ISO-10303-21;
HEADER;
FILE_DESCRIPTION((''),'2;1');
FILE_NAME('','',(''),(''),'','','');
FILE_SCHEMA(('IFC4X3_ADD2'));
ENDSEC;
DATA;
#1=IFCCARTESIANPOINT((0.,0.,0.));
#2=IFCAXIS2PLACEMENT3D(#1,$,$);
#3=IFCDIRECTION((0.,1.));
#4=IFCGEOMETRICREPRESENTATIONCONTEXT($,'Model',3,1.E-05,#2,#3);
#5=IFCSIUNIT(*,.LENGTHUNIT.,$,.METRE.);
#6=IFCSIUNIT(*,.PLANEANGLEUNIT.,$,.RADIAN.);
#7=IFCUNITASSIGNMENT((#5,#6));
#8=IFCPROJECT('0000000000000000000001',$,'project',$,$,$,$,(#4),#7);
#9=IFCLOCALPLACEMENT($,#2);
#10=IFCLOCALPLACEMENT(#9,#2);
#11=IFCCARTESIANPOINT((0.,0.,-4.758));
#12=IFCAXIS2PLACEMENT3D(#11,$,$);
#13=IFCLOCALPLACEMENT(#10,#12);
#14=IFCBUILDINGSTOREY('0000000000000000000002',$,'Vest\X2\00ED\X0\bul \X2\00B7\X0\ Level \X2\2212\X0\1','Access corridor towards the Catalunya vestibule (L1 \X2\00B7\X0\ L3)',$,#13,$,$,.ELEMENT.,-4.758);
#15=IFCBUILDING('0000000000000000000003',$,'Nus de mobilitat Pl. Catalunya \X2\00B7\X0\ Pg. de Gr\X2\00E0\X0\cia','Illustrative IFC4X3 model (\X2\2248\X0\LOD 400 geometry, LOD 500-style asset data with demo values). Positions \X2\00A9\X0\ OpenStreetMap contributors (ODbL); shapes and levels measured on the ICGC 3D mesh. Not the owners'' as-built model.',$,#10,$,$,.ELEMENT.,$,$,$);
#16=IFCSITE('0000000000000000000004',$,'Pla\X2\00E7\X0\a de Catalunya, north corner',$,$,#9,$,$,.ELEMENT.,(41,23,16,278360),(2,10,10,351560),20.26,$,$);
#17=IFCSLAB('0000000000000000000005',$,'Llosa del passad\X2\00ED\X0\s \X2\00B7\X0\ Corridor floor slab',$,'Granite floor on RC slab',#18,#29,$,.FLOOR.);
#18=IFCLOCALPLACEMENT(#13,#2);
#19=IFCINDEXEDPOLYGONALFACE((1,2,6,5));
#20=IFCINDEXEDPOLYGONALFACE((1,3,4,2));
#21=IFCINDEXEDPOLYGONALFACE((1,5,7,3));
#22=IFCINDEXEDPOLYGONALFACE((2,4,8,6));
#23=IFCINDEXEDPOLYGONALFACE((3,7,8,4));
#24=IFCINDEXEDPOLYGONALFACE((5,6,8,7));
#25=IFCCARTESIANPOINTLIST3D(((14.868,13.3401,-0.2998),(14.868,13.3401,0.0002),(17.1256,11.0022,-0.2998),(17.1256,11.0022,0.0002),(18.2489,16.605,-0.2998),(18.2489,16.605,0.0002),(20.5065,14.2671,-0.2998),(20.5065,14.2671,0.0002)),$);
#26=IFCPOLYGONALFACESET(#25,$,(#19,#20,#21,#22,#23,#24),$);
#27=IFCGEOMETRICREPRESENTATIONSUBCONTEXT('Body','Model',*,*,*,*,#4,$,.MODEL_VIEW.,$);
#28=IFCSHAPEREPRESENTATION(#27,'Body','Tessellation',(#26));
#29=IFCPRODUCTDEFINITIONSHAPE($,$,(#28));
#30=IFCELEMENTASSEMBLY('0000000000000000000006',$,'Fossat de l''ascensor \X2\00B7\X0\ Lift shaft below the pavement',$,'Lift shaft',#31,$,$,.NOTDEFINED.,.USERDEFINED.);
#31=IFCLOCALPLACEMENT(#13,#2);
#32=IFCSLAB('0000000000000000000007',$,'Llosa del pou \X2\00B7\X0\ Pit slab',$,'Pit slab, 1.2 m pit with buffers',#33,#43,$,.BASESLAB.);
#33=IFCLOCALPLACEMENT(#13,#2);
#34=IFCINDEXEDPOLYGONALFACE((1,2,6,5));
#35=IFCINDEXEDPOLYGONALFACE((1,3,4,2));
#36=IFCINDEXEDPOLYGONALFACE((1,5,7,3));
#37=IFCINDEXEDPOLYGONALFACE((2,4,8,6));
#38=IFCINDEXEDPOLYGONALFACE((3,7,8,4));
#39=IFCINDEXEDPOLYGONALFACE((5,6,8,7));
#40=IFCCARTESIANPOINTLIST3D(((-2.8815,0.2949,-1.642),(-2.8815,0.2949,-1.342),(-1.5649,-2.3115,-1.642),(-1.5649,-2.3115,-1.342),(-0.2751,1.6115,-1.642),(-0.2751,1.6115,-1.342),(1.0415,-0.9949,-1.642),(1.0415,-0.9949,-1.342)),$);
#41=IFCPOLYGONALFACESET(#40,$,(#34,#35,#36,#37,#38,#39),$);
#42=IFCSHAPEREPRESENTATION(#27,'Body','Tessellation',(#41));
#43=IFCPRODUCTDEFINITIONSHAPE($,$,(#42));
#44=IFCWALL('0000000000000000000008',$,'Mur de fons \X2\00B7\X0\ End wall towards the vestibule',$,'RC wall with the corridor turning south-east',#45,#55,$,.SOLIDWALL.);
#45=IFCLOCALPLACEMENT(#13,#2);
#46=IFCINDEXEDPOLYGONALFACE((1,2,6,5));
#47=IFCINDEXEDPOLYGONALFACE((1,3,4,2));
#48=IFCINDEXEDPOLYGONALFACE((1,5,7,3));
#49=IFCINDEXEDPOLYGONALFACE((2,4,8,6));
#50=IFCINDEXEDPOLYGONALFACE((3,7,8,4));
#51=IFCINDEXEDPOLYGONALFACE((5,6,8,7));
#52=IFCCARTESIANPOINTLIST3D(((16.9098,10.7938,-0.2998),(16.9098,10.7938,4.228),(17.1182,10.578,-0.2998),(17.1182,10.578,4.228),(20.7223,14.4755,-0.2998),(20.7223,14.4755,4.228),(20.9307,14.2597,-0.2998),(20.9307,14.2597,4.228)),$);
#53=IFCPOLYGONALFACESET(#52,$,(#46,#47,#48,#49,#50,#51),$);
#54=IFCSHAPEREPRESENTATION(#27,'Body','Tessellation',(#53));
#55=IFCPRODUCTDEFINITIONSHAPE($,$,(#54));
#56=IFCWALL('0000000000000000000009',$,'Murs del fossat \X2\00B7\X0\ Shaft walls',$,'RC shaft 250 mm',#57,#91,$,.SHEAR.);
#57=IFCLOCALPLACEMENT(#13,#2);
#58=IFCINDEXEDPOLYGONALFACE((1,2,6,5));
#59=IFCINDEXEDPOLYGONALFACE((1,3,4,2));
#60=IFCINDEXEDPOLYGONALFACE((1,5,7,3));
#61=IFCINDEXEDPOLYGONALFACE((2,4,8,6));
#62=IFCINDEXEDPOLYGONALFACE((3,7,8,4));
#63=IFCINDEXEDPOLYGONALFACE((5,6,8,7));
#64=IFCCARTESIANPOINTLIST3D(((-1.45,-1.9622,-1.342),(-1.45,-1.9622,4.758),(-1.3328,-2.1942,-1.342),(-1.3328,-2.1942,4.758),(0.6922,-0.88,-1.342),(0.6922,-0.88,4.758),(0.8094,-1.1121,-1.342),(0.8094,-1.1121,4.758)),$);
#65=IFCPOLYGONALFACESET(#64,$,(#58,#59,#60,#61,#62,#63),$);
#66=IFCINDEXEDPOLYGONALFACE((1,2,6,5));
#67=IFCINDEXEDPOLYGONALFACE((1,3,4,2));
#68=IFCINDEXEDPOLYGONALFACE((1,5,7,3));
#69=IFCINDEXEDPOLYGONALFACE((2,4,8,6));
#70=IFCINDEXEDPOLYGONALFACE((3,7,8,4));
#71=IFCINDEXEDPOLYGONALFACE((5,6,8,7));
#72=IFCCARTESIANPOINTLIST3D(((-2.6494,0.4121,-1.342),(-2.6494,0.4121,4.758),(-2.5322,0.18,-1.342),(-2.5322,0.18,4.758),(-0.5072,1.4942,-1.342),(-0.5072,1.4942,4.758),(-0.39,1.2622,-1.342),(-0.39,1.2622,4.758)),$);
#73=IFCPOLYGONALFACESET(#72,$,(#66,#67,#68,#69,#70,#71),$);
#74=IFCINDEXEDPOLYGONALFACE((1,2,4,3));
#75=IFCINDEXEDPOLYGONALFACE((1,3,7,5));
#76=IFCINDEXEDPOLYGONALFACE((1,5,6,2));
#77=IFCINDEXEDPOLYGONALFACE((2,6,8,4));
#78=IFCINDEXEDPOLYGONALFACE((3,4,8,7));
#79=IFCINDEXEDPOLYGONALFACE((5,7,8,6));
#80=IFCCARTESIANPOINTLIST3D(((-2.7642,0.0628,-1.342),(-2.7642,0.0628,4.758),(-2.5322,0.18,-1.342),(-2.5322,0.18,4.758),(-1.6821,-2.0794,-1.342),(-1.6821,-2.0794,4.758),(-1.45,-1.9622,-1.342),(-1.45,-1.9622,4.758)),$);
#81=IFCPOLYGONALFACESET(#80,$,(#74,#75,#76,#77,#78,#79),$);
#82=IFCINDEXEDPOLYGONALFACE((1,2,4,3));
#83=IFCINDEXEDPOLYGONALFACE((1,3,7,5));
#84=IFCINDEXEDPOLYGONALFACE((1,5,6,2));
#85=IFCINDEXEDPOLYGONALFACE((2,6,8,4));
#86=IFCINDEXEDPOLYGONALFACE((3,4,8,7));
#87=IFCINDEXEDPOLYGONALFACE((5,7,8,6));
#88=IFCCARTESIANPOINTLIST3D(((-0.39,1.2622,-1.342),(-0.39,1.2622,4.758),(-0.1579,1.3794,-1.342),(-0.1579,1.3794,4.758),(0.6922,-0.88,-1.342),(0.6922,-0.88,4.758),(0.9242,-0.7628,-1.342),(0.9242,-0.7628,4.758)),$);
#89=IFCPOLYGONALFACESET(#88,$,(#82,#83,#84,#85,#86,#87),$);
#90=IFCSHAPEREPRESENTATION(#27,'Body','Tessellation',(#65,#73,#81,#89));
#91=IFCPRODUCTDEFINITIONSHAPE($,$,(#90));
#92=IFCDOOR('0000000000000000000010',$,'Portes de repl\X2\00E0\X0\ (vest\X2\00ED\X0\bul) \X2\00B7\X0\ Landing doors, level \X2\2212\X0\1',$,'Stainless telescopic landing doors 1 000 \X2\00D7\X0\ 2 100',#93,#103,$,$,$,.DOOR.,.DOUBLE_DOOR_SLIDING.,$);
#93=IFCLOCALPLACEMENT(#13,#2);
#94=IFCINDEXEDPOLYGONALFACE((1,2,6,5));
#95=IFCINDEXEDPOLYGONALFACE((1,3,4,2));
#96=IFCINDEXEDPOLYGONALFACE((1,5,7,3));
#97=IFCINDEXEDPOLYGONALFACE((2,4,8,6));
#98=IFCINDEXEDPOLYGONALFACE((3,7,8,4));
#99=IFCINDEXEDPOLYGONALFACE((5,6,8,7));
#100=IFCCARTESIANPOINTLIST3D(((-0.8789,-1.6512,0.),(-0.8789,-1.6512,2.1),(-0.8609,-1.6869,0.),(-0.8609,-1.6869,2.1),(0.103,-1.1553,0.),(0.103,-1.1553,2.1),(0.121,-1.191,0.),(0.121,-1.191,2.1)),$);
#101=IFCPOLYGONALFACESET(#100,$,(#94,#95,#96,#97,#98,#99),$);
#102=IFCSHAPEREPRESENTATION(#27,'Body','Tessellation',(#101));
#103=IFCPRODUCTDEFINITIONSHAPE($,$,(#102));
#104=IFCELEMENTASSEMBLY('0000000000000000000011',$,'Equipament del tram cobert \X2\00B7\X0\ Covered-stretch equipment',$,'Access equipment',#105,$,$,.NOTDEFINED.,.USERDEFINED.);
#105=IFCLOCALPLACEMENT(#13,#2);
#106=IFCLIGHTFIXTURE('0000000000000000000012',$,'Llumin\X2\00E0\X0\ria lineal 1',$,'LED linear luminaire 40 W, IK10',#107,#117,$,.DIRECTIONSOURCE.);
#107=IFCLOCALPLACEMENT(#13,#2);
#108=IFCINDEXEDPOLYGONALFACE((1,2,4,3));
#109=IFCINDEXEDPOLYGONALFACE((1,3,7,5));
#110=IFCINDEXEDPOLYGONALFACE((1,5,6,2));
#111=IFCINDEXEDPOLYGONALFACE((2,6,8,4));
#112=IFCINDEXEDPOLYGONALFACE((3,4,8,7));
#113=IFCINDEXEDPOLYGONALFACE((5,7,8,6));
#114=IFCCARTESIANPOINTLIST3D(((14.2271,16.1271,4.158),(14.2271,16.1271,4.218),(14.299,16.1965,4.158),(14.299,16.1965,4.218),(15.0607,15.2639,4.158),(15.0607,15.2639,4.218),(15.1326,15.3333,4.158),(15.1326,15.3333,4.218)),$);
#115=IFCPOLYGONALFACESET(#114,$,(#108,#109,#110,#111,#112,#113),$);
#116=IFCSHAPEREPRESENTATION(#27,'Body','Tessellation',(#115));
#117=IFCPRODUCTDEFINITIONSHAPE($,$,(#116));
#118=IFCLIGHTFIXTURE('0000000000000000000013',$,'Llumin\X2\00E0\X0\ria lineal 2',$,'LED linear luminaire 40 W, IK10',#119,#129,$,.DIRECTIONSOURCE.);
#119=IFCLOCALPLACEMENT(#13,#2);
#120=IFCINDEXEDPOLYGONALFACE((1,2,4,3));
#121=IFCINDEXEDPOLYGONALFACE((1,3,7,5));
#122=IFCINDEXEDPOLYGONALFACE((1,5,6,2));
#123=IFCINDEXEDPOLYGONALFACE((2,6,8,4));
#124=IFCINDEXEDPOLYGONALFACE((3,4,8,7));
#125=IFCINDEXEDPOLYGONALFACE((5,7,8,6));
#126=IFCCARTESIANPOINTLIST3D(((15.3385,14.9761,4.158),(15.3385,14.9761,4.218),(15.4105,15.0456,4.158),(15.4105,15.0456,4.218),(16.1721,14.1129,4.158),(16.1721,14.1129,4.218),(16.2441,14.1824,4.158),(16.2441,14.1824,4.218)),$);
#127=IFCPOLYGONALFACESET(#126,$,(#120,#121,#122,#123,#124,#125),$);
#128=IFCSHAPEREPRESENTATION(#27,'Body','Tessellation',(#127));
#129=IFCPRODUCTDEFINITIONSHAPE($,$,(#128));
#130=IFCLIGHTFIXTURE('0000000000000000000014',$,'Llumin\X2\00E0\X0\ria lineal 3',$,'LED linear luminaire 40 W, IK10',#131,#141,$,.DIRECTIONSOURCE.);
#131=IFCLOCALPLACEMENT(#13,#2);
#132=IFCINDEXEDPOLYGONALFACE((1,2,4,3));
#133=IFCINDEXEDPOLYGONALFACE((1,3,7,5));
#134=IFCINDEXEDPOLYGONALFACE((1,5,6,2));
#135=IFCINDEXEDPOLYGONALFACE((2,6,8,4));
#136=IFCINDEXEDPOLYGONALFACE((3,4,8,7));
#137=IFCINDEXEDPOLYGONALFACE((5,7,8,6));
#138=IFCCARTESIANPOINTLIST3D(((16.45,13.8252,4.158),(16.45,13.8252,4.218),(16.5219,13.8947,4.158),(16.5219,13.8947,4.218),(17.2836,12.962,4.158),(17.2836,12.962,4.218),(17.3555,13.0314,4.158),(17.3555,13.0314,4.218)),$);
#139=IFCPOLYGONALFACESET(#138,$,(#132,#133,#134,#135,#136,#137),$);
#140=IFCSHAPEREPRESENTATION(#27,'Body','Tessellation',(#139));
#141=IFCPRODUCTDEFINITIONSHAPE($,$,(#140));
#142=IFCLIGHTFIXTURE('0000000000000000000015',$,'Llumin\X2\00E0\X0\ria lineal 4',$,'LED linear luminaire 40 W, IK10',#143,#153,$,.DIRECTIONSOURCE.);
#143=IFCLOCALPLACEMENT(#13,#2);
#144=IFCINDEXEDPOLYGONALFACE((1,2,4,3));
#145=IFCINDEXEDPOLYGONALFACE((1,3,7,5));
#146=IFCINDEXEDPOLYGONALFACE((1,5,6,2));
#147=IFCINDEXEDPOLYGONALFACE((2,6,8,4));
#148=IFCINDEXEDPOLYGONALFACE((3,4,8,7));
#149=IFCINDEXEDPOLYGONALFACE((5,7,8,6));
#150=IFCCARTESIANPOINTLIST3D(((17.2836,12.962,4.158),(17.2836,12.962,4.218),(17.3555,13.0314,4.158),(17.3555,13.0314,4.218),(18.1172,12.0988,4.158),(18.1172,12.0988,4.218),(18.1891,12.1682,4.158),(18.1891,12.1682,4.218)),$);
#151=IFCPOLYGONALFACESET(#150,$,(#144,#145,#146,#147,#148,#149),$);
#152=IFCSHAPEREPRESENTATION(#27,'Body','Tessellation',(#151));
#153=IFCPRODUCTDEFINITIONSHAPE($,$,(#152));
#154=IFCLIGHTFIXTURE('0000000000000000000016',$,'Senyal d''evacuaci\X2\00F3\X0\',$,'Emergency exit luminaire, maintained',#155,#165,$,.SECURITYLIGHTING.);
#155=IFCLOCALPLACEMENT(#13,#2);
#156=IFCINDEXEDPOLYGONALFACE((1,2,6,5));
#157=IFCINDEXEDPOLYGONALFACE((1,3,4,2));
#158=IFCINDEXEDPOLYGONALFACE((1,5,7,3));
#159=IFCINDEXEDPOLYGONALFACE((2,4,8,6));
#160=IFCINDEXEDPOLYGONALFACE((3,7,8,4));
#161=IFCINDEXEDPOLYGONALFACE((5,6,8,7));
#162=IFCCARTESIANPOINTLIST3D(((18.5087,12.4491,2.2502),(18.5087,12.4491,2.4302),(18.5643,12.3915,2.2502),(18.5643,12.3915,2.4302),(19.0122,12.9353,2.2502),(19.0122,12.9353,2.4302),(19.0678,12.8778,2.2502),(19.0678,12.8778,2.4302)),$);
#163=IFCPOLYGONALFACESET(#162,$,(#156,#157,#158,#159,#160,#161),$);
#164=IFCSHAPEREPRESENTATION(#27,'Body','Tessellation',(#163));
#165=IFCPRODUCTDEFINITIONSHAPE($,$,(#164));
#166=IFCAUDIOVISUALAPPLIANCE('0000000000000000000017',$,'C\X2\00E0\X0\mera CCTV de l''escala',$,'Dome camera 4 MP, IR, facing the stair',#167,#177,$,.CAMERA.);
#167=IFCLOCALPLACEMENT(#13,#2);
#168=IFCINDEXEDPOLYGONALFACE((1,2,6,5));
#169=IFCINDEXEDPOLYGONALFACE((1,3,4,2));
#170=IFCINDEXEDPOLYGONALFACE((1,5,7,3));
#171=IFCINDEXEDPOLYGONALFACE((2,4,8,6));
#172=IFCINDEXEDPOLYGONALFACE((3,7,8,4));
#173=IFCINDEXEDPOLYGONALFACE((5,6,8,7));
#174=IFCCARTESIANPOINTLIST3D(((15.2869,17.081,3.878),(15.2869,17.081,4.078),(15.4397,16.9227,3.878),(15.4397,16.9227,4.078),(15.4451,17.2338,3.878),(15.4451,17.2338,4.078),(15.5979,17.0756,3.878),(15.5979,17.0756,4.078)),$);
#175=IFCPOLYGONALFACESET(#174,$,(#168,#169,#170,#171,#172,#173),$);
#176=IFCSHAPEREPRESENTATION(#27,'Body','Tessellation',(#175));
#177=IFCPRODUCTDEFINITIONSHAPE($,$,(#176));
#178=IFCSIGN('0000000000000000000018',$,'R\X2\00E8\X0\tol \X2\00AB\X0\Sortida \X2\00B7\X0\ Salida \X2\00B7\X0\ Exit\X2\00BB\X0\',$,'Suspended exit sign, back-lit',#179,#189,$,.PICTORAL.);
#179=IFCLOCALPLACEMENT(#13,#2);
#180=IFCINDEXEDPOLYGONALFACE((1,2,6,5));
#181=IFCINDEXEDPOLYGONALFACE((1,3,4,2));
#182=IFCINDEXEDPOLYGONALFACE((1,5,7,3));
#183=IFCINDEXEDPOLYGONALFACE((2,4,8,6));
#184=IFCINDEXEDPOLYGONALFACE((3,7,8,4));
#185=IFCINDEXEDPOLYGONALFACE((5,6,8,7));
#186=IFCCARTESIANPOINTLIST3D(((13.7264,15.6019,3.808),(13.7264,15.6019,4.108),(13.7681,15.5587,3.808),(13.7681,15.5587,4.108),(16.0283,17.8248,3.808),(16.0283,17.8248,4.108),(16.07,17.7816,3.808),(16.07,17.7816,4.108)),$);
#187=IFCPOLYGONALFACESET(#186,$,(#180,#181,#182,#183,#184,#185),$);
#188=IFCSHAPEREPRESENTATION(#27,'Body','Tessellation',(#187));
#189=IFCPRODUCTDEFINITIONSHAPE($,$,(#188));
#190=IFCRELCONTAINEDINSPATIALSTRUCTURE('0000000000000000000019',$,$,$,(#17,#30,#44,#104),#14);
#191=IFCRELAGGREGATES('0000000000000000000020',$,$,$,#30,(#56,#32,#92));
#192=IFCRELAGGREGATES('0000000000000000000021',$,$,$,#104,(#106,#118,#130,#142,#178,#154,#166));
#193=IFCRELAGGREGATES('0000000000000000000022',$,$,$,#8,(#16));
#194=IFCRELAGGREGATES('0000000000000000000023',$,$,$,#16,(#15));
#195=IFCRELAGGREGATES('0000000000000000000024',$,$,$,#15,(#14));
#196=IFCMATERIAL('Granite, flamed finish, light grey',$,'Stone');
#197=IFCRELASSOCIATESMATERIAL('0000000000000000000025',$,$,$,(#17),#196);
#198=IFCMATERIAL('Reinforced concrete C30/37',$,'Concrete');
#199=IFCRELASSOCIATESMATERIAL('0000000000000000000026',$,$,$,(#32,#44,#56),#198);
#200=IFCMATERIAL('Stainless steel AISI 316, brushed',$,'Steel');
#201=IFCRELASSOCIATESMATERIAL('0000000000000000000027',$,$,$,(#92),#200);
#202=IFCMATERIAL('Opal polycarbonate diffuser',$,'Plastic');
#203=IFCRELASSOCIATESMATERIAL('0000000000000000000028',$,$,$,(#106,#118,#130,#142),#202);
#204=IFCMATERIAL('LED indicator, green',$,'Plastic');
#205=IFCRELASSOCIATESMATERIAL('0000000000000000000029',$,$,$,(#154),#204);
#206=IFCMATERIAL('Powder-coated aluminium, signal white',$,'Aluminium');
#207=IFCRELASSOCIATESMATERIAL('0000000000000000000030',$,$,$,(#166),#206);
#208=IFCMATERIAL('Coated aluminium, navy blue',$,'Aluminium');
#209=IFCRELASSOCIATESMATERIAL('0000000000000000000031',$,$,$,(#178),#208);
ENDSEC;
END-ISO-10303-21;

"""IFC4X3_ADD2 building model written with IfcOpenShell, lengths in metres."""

from ifc_helpers import new_model, si_unit, direction, frame, frame_2d, origin, place, context, subcontext, project, spatial, rectangle, extrude, material, element, aggregate, save


model = new_model("IFC4X3_ADD2")

# Units and contexts
model_context = context("Model", 3, precision=1e-05, world=origin(), true_north=direction((0.0, 1.0)))
body_context = subcontext(model_context, "Body", "Model", "MODEL_VIEW")
ifc_project = project(units=[si_unit("LENGTHUNIT", "METRE"), si_unit("PLANEANGLEUNIT", "RADIAN")], contexts=[model_context])

# Site, building, storey
site_placement = place(None, origin())
site = spatial("IfcSite", under=ifc_project, at=site_placement, Name="Plaça de Catalunya, north corner", CompositionType="ELEMENT", RefLatitude=(41, 23, 16, 278360), RefLongitude=(2, 10, 10, 351560), RefElevation=20.26)
building_placement = place(site_placement, origin())
building = spatial("IfcBuilding", under=site, at=building_placement, Name="Nus de mobilitat Pl. Catalunya · Pg. de Gràcia", Description="Illustrative IFC4X3 model (≈LOD 400 geometry, LOD 500-style asset data with demo values). Positions © OpenStreetMap contributors (ODbL); shapes and levels measured on the ICGC 3D mesh. Not the owners' as-built model.", CompositionType="ELEMENT")
storey_placement = place(building_placement, frame((0.0, 0.0, -4.758)))
storey = spatial("IfcBuildingStorey", under=building, at=storey_placement, Name="Vestíbul · Level −1", Description="Access corridor towards the Catalunya vestibule (L1 · L3)", CompositionType="ELEMENT", Elevation=-4.758)

# Slab
ifc_material_1 = material(Name="Granite, flamed finish, light grey", Category="Stone")
slab_1_placement = place(building_placement, origin())
element("IfcSlab", 1, at=slab_1_placement, inside=storey, material=ifc_material_1, Name="Llosa del passadís · Corridor floor slab", ObjectType="Granite floor on RC slab", PredefinedType="FLOOR", context=body_context, shape_type="SweptSolid", body=[
    extrude(rectangle(XDim=3.25, YDim=4.7, at=frame_2d((0.0, 0.0), x_axis=(0.694658, -0.71934))), frame((17.6872, 13.8036, -5.0578)), (0.0, 0.0, 1.0), 0.3),
])

# Element assembly, slab
assembly_1_placement = place(building_placement, origin())
assembly_1 = element("IfcElementAssembly", 2, at=assembly_1_placement, inside=storey, Name="Fossat de l'ascensor · Lift shaft below the pavement", ObjectType="Lift shaft", AssemblyPlace="NOTDEFINED", PredefinedType="USERDEFINED")
ifc_material_2 = material(Name="Reinforced concrete C30/37", Category="Concrete")
slab_2_placement = place(building_placement, origin())
slab_2 = element("IfcSlab", 3, at=slab_2_placement, material=ifc_material_2, Name="Llosa del pou · Pit slab", ObjectType="Pit slab, 1.2 m pit with buffers", PredefinedType="BASESLAB", context=body_context, shape_type="SweptSolid", body=[
    extrude(rectangle(XDim=2.92, YDim=2.92, at=frame_2d((0.0, 0.0), x_axis=(0.892586, 0.450878))), frame((-0.92, -0.35, -6.4)), (0.0, 0.0, 1.0), 0.3),
])

# Walls
wall_1_placement = place(building_placement, origin())
element("IfcWall", 4, at=wall_1_placement, inside=storey, material=ifc_material_2, Name="Mur de fons · End wall towards the vestibule", ObjectType="RC wall with the corridor turning south-east", PredefinedType="SOLIDWALL", context=body_context, shape_type="SweptSolid", body=[
    extrude(rectangle(XDim=0.3, YDim=5.3, at=frame_2d((0.0, 0.0), x_axis=(0.694658, -0.71934))), frame((18.9202, 12.5268, -5.0578)), (0.0, 0.0, 1.0), 4.5278),
])
wall_2_placement = place(building_placement, origin())
wall_2 = element("IfcWall", 5, at=wall_2_placement, material=ifc_material_2, Name="Murs del fossat · Shaft walls", ObjectType="RC shaft 250 mm", PredefinedType="SHEAR", context=body_context, shape_type="SweptSolid", body=[
    extrude(rectangle(XDim=2.4, YDim=0.26, at=frame_2d((0.0, 0.0), x_axis=(0.892586, 0.450878))), frame((-0.3203, -1.5371, -6.1)), (0.0, 0.0, 1.0), 6.1),
    extrude(rectangle(XDim=2.4, YDim=0.26, at=frame_2d((0.0, 0.0), x_axis=(0.892586, 0.450878))), frame((-1.5197, 0.8371, -6.1)), (0.0, 0.0, 1.0), 6.1),
    extrude(rectangle(XDim=0.26, YDim=2.4, at=frame_2d((0.0, 0.0), x_axis=(0.892586, 0.450878))), frame((-2.1071, -0.9497, -6.1)), (0.0, 0.0, 1.0), 6.1),
    extrude(rectangle(XDim=0.26, YDim=2.4, at=frame_2d((0.0, 0.0), x_axis=(0.892586, 0.450878))), frame((0.2671, 0.2497, -6.1)), (0.0, 0.0, 1.0), 6.1),
])

# Door
ifc_material_3 = material(Name="Stainless steel AISI 316, brushed", Category="Steel")
door_placement = place(building_placement, origin())
door = element("IfcDoor", 6, at=door_placement, material=ifc_material_3, Name="Portes de replà (vestíbul) · Landing doors, level −1", ObjectType="Stainless telescopic landing doors 1 000 × 2 100", OperationType="DOUBLE_DOOR_SLIDING", PredefinedType="DOOR", context=body_context, shape_type="SweptSolid", body=[
    extrude(rectangle(XDim=1.1, YDim=0.04, at=frame_2d((0.0, 0.0), x_axis=(0.892586, 0.450878))), frame((-0.3789, -1.4211, -4.758)), (0.0, 0.0, 1.0), 2.1),
])
aggregate(assembly_1, [wall_2, slab_2, door])

# Element assembly, light fixtures, audio visual appliance, sign
assembly_2_placement = place(building_placement, origin())
assembly_2 = element("IfcElementAssembly", 7, at=assembly_2_placement, inside=storey, Name="Equipament del tram cobert · Covered-stretch equipment", ObjectType="Access equipment", AssemblyPlace="NOTDEFINED", PredefinedType="USERDEFINED")
ifc_material_4 = material(Name="Opal polycarbonate diffuser", Category="Plastic")
light_fixture_1_placement = place(building_placement, origin())
light_fixture_1 = element("IfcLightFixture", 8, at=light_fixture_1_placement, material=ifc_material_4, Name="Lluminària lineal 1", ObjectType="LED linear luminaire 40 W, IK10", PredefinedType="DIRECTIONSOURCE", context=body_context, shape_type="SweptSolid", body=[
    extrude(rectangle(XDim=1.2, YDim=0.1, at=frame_2d((0.0, 0.0), x_axis=(0.694658, -0.71934))), frame((14.6798, 15.7302, -0.6)), (0.0, 0.0, 1.0), 0.06),
])
light_fixture_2_placement = place(building_placement, origin())
light_fixture_2 = element("IfcLightFixture", 9, at=light_fixture_2_placement, material=ifc_material_4, Name="Lluminària lineal 2", ObjectType="LED linear luminaire 40 W, IK10", PredefinedType="DIRECTIONSOURCE", context=body_context, shape_type="SweptSolid", body=[
    extrude(rectangle(XDim=1.2, YDim=0.1, at=frame_2d((0.0, 0.0), x_axis=(0.694658, -0.71934))), frame((15.7913, 14.5793, -0.6)), (0.0, 0.0, 1.0), 0.06),
])
light_fixture_3_placement = place(building_placement, origin())
light_fixture_3 = element("IfcLightFixture", 10, at=light_fixture_3_placement, material=ifc_material_4, Name="Lluminària lineal 3", ObjectType="LED linear luminaire 40 W, IK10", PredefinedType="DIRECTIONSOURCE", context=body_context, shape_type="SweptSolid", body=[
    extrude(rectangle(XDim=1.2, YDim=0.1, at=frame_2d((0.0, 0.0), x_axis=(0.694658, -0.71934))), frame((16.9027, 13.4283, -0.6)), (0.0, 0.0, 1.0), 0.06),
])
light_fixture_4_placement = place(building_placement, origin())
light_fixture_4 = element("IfcLightFixture", 11, at=light_fixture_4_placement, material=ifc_material_4, Name="Lluminària lineal 4", ObjectType="LED linear luminaire 40 W, IK10", PredefinedType="DIRECTIONSOURCE", context=body_context, shape_type="SweptSolid", body=[
    extrude(rectangle(XDim=1.2, YDim=0.1, at=frame_2d((0.0, 0.0), x_axis=(0.694658, -0.71934))), frame((17.7363, 12.5651, -0.6)), (0.0, 0.0, 1.0), 0.06),
])
ifc_material_5 = material(Name="LED indicator, green", Category="Plastic")
light_fixture_5_placement = place(building_placement, origin())
light_fixture_5 = element("IfcLightFixture", 12, at=light_fixture_5_placement, material=ifc_material_5, Name="Senyal d'evacuació", ObjectType="Emergency exit luminaire, maintained", PredefinedType="SECURITYLIGHTING", context=body_context, shape_type="SweptSolid", body=[
    extrude(rectangle(XDim=0.08, YDim=0.7, at=frame_2d((0.0, 0.0), x_axis=(0.694658, -0.71934))), frame((18.7883, 12.6634, -2.5078)), (0.0, 0.0, 1.0), 0.18),
])
ifc_material_6 = material(Name="Powder-coated aluminium, signal white", Category="Aluminium")
audio_visual_appliance_placement = place(building_placement, origin())
audio_visual_appliance = element("IfcAudioVisualAppliance", 13, at=audio_visual_appliance_placement, material=ifc_material_6, Name="Càmera CCTV de l'escala", ObjectType="Dome camera 4 MP, IR, facing the stair", PredefinedType="CAMERA", context=body_context, shape_type="SweptSolid", body=[
    extrude(rectangle(XDim=0.22, YDim=0.22, at=frame_2d((0.0, 0.0), x_axis=(0.694658, -0.71934))), frame((15.4424, 17.0783, -0.88)), (0.0, 0.0, 1.0), 0.2),
])
ifc_material_7 = material(Name="Coated aluminium, navy blue", Category="Aluminium")
sign_placement = place(building_placement, origin())
sign = element("IfcSign", 14, at=sign_placement, material=ifc_material_7, Name="Rètol «Sortida · Salida · Exit»", ObjectType="Suspended exit sign, back-lit", PredefinedType="PICTORAL", context=body_context, shape_type="SweptSolid", body=[
    extrude(rectangle(XDim=0.06, YDim=3.2, at=frame_2d((0.0, 0.0), x_axis=(0.694658, -0.71934))), frame((14.8982, 16.6917, -0.95)), (0.0, 0.0, 1.0), 0.3),
])
aggregate(assembly_2, [light_fixture_1, light_fixture_2, light_fixture_3, light_fixture_4, sign, light_fixture_5, audio_visual_appliance])

save(model, "model.ifc")
